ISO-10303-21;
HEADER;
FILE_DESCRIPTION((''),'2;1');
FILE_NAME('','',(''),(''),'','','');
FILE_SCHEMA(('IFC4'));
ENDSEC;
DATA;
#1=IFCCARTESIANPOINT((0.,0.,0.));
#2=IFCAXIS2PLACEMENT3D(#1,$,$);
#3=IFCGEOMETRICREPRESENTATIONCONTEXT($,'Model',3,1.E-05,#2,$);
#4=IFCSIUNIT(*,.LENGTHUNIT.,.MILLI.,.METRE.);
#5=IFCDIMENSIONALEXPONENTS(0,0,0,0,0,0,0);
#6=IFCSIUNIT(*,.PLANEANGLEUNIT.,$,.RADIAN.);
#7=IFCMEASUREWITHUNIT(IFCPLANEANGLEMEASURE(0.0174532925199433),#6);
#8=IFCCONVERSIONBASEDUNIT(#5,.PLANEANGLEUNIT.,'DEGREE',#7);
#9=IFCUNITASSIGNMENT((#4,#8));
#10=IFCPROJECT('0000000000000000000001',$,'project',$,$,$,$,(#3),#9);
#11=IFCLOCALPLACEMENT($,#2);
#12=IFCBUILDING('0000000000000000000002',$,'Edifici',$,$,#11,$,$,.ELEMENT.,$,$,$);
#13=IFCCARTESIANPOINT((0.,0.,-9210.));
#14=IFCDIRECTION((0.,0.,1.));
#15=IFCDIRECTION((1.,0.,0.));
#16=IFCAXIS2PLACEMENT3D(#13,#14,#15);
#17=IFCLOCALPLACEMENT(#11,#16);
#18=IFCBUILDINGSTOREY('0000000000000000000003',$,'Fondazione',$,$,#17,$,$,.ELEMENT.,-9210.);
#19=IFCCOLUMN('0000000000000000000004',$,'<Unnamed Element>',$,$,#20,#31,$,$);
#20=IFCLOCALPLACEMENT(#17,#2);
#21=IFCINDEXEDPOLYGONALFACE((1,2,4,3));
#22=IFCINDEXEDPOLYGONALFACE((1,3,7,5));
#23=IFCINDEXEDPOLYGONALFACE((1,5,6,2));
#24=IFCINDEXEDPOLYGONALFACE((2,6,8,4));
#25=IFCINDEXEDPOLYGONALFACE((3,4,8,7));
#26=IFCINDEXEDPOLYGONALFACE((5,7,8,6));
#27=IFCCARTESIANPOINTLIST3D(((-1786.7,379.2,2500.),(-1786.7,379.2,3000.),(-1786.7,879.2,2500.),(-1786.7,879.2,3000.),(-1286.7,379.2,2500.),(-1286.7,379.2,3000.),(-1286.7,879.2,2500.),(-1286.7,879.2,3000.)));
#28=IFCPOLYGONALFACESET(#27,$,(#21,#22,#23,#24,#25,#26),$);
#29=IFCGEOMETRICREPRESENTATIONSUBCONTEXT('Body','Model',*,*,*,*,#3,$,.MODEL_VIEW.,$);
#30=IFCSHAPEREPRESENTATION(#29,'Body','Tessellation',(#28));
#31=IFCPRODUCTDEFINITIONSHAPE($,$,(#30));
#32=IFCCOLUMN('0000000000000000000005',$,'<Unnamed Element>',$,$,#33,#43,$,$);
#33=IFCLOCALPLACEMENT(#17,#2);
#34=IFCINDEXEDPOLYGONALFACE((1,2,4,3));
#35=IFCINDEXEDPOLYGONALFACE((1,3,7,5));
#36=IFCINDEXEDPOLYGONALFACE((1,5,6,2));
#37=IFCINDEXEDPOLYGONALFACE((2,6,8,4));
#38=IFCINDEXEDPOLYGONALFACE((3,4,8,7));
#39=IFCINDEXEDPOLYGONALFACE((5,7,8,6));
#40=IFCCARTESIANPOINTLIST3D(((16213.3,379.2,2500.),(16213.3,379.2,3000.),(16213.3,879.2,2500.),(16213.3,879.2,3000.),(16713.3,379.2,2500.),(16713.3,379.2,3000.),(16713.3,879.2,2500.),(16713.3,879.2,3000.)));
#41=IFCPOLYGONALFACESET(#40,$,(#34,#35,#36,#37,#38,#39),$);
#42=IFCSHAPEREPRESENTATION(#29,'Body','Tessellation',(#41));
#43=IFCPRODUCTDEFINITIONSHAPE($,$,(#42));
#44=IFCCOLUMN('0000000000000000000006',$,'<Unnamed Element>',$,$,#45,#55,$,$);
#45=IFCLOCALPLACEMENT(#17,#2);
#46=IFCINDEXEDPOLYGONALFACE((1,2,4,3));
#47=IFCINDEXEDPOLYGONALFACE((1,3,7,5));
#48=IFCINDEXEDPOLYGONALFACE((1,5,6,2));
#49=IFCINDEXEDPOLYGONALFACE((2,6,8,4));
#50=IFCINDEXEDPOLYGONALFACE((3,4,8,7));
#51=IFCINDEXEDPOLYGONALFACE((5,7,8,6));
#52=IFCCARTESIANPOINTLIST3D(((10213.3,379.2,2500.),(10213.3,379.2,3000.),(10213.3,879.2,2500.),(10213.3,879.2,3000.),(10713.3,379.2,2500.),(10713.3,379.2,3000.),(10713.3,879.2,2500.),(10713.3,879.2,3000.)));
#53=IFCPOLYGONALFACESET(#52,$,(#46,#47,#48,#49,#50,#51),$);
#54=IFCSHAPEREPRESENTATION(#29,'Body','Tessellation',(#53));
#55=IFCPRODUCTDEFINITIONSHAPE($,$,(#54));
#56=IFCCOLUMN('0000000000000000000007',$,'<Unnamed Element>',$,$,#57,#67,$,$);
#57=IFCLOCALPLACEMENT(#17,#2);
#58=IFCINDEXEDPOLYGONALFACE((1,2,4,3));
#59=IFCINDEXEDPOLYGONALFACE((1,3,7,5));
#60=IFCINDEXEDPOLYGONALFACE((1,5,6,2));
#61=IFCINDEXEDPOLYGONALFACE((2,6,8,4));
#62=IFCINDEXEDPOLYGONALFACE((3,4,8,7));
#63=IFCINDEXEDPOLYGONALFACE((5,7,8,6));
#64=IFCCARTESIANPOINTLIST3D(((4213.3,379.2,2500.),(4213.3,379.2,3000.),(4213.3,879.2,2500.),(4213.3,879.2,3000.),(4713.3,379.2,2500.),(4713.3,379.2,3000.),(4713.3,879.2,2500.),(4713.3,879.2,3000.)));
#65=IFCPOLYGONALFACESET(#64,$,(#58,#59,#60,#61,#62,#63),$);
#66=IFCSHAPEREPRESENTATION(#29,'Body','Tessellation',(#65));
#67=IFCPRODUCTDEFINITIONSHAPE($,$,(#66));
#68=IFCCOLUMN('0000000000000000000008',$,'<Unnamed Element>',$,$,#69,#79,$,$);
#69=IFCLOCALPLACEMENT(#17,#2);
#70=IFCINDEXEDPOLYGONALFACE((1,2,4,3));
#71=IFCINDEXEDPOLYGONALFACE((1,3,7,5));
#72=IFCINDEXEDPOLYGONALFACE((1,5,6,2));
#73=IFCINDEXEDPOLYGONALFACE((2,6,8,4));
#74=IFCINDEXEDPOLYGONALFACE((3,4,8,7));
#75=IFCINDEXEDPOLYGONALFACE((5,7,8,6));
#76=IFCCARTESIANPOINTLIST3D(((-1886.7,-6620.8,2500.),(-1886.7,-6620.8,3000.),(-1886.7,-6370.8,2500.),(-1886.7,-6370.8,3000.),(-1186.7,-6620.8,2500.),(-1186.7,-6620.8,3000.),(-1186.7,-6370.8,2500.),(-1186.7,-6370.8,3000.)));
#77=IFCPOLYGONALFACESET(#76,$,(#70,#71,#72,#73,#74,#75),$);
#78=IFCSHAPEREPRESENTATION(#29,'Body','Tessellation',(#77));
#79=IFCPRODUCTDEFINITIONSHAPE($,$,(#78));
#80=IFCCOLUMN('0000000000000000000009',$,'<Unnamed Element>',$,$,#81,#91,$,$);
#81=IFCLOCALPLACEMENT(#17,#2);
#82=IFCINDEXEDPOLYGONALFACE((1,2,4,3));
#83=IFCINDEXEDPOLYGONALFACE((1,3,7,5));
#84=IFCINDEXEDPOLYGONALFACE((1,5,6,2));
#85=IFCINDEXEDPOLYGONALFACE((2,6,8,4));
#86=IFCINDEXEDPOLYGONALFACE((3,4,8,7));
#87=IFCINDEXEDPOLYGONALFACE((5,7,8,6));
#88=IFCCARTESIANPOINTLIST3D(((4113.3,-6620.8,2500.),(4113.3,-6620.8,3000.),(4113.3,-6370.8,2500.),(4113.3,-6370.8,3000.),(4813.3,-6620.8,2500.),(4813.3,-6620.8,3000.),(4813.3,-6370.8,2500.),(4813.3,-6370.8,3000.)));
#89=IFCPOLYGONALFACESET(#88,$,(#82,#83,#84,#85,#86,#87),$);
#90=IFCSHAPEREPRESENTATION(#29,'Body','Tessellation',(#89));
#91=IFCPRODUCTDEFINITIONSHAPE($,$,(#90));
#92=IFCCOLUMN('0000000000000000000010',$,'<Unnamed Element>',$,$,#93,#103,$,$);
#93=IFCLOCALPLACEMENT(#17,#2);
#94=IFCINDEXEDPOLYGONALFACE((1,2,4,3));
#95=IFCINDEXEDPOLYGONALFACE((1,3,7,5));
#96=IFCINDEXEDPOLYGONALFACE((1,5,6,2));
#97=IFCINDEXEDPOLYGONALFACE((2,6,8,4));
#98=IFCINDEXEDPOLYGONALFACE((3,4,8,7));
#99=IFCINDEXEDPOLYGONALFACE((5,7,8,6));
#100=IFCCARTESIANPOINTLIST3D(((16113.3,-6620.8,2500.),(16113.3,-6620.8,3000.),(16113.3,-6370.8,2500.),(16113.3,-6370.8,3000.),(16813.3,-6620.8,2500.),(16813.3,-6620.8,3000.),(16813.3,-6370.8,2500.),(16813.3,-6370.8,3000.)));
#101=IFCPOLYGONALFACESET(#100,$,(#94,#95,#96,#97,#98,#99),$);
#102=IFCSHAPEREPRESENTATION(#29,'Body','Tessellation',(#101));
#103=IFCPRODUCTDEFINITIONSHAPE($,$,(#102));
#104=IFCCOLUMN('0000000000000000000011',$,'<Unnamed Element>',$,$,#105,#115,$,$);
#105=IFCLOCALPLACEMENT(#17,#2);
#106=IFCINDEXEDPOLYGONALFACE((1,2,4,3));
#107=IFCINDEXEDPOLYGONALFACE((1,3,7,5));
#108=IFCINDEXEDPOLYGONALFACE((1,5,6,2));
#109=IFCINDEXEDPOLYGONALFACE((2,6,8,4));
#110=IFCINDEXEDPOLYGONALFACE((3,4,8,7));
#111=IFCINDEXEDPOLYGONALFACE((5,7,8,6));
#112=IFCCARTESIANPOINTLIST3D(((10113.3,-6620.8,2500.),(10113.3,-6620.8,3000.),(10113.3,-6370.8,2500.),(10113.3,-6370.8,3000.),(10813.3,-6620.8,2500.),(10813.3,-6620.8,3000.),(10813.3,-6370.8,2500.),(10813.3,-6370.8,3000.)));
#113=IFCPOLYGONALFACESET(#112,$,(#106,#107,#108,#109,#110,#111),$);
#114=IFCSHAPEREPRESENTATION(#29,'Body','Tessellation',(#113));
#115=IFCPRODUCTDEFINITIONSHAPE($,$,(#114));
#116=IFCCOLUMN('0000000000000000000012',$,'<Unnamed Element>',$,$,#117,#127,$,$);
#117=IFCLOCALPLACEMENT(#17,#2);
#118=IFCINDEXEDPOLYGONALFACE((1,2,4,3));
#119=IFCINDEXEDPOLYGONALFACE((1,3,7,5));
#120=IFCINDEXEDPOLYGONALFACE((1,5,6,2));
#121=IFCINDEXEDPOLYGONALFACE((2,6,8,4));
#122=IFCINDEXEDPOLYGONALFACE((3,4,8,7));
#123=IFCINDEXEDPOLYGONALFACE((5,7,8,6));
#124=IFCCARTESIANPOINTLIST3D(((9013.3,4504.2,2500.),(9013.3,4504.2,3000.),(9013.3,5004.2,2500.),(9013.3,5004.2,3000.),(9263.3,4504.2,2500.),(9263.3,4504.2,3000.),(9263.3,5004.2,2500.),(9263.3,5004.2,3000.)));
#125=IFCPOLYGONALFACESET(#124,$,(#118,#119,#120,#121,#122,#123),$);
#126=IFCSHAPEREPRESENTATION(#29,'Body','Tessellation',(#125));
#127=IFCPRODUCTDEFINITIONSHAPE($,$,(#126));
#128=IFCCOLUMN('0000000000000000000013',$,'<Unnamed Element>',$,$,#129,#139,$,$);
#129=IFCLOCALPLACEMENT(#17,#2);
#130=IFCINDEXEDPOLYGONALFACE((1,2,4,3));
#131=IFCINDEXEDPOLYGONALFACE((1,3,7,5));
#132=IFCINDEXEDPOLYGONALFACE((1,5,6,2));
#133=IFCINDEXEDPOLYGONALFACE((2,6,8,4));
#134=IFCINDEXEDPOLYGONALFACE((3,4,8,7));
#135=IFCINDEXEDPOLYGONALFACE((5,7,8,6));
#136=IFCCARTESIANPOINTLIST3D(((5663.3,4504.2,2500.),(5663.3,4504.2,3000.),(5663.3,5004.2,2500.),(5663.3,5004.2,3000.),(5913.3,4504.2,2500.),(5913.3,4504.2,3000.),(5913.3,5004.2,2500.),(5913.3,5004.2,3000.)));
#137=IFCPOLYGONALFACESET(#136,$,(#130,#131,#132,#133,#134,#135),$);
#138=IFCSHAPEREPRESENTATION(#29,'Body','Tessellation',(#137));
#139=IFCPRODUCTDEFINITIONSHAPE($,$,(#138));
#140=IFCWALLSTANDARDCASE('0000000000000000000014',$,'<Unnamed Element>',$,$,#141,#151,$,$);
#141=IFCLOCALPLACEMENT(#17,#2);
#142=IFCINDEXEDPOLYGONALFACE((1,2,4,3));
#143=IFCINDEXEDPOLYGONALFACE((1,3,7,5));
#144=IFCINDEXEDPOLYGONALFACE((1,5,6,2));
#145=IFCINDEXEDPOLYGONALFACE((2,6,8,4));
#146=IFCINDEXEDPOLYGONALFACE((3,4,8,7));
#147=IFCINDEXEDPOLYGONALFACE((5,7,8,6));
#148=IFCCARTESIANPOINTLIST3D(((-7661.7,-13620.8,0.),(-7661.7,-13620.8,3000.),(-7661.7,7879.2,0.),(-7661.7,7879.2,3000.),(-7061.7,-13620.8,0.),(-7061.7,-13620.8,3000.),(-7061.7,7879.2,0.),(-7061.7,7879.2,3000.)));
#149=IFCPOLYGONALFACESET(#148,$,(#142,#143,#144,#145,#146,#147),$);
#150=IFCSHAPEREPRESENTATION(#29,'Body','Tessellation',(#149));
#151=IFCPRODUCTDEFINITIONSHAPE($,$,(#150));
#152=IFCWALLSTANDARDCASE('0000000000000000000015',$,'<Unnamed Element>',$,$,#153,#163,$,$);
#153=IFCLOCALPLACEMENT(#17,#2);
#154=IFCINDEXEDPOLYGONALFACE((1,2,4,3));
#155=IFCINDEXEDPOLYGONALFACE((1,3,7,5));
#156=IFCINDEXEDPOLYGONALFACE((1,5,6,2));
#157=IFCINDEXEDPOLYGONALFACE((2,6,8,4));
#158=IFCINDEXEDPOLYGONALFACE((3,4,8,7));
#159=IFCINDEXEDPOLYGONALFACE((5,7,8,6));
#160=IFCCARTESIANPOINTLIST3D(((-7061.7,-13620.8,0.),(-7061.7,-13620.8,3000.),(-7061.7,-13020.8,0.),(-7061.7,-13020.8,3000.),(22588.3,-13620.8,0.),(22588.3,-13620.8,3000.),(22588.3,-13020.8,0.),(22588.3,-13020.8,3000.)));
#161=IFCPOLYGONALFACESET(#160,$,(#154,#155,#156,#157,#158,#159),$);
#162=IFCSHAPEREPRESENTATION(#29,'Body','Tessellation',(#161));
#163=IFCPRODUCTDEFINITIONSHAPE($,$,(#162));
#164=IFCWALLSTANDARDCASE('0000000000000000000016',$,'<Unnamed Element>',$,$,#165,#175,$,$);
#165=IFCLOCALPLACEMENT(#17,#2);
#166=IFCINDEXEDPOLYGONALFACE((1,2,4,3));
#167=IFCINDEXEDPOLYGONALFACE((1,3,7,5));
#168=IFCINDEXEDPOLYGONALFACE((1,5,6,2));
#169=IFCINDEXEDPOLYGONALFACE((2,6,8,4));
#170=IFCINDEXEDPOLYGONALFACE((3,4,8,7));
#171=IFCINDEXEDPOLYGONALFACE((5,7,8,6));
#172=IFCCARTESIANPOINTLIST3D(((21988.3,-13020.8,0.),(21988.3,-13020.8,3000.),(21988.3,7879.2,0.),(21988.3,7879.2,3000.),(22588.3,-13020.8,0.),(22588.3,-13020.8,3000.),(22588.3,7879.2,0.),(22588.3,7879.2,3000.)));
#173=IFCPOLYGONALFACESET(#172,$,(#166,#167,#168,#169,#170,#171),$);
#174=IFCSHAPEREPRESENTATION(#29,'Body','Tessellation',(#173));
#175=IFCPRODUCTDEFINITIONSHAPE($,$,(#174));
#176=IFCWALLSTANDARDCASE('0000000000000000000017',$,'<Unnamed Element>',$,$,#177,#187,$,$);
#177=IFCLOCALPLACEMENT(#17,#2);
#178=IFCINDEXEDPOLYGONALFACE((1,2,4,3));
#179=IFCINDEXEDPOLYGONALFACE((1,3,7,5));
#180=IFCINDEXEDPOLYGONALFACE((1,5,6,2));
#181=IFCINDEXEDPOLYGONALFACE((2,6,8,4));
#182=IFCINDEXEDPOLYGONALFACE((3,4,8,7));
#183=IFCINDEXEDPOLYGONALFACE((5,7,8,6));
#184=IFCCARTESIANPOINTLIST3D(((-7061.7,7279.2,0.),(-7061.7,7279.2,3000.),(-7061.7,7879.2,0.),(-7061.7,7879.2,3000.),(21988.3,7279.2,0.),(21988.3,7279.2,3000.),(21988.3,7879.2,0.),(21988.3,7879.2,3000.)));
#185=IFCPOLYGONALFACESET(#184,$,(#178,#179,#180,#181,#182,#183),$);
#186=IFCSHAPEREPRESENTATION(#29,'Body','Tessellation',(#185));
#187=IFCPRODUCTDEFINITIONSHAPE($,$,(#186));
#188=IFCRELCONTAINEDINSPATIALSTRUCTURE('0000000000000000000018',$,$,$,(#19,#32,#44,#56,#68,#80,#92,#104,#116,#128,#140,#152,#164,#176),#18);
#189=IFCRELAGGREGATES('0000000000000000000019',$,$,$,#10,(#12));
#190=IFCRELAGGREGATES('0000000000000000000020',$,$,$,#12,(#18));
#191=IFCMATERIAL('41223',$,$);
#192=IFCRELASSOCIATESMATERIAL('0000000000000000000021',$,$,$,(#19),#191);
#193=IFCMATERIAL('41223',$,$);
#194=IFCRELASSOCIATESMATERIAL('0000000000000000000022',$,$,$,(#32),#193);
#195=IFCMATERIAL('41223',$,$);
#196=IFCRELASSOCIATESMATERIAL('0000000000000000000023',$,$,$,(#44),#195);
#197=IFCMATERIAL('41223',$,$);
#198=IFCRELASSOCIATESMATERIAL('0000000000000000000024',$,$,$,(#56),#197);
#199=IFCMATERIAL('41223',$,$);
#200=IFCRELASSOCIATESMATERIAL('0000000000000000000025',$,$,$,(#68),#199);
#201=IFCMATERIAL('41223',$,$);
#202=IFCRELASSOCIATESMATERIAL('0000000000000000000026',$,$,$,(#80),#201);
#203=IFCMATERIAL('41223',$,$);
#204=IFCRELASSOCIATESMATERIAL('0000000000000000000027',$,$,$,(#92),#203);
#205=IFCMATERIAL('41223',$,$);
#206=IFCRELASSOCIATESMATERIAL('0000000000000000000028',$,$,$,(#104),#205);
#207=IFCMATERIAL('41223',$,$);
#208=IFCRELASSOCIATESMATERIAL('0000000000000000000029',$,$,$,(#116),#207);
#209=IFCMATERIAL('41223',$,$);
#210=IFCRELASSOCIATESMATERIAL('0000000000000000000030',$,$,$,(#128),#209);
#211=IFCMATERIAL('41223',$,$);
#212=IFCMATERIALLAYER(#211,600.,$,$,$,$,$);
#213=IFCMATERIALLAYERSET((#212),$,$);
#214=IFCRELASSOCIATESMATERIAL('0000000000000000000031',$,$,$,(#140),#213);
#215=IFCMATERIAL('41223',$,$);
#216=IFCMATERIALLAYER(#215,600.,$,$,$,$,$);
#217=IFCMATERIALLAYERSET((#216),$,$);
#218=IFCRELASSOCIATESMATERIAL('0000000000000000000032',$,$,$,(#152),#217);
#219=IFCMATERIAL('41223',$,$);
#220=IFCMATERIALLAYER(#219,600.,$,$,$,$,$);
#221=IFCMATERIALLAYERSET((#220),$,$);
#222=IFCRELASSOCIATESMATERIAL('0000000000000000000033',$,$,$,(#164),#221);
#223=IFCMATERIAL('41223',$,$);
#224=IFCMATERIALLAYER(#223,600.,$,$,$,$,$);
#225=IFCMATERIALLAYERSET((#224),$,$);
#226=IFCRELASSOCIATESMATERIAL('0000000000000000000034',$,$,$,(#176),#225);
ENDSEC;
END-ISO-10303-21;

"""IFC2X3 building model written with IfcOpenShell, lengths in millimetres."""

from ifc_helpers import new_model, entity, si_unit, converted_unit, frame, frame_2d, origin, origin_with_axes, place, context, subcontext, project, spatial, rectangle, extrude, material, layer, layer_set, layer_usage, element, save


model = new_model("IFC2X3")

# Units and contexts
model_context = context("Model", 3, precision=1e-05, world=origin())
body_context = subcontext(model_context, "Body", "Model", "MODEL_VIEW")
ifc_project = project(units=[si_unit("LENGTHUNIT", "METRE", prefix="MILLI"), converted_unit("PLANEANGLEUNIT", "DEGREE", entity("IfcPlaneAngleMeasure", 0.0174532925199433), si_unit("PLANEANGLEUNIT", "RADIAN"), dimensions=[0, 0, 0, 0, 0, 0, 0])], contexts=[model_context])

# Building, storey
building_placement = place(None, origin())
building = spatial("IfcBuilding", under=ifc_project, at=building_placement, Name="Edifici", CompositionType="ELEMENT")
storey_placement = place(building_placement, frame((0.0, 0.0, -9210.0), z_axis=(0.0, 0.0, 1.0), x_axis=(1.0, 0.0, 0.0)))
storey = spatial("IfcBuildingStorey", under=building, at=storey_placement, Name="Fondazione", CompositionType="ELEMENT", Elevation=-9210.0)

# Columns
ifc_material_1 = material(Name="41223")
column_1_placement = place(storey_placement, frame((-1786.7, 379.2, 2500.0), z_axis=(0.0, 0.0, 1.0), x_axis=(1.0, 0.0, 0.0)))
element("IfcColumn", 1, at=column_1_placement, inside=storey, material=ifc_material_1, Name="<Unnamed Element>", context=body_context, shape_type="SweptSolid", body=[
    extrude(rectangle(XDim=500.0, YDim=500.0, at=frame_2d((250.0, 250.0), x_axis=(1.0, 0.0))), origin_with_axes(), (0.0, 0.0, 1.0), 500.0),
])
ifc_material_2 = material(Name="41223")
column_2_placement = place(storey_placement, frame((16213.3, 379.2, 2500.0), z_axis=(0.0, 0.0, 1.0), x_axis=(1.0, 0.0, 0.0)))
element("IfcColumn", 2, at=column_2_placement, inside=storey, material=ifc_material_2, Name="<Unnamed Element>", context=body_context, shape_type="SweptSolid", body=[
    extrude(rectangle(XDim=500.0, YDim=500.0, at=frame_2d((250.0, 250.0), x_axis=(1.0, 0.0))), origin_with_axes(), (0.0, 0.0, 1.0), 500.0),
])
ifc_material_3 = material(Name="41223")
column_3_placement = place(storey_placement, frame((10213.3, 379.2, 2500.0), z_axis=(0.0, 0.0, 1.0), x_axis=(1.0, 0.0, 0.0)))
element("IfcColumn", 3, at=column_3_placement, inside=storey, material=ifc_material_3, Name="<Unnamed Element>", context=body_context, shape_type="SweptSolid", body=[
    extrude(rectangle(XDim=500.0, YDim=500.0, at=frame_2d((250.0, 250.0), x_axis=(1.0, 0.0))), origin_with_axes(), (0.0, 0.0, 1.0), 500.0),
])
ifc_material_4 = material(Name="41223")
column_4_placement = place(storey_placement, frame((4213.3, 379.2, 2500.0), z_axis=(0.0, 0.0, 1.0), x_axis=(1.0, 0.0, 0.0)))
element("IfcColumn", 4, at=column_4_placement, inside=storey, material=ifc_material_4, Name="<Unnamed Element>", context=body_context, shape_type="SweptSolid", body=[
    extrude(rectangle(XDim=500.0, YDim=500.0, at=frame_2d((250.0, 250.0), x_axis=(1.0, 0.0))), origin_with_axes(), (0.0, 0.0, 1.0), 500.0),
])
ifc_material_5 = material(Name="41223")
column_5_placement = place(storey_placement, frame((-1186.7, -6620.8, 2500.0), z_axis=(0.0, 0.0, 1.0), x_axis=(1.0, 0.0, 0.0)))
element("IfcColumn", 5, at=column_5_placement, inside=storey, material=ifc_material_5, Name="<Unnamed Element>", context=body_context, shape_type="SweptSolid", body=[
    extrude(rectangle(XDim=250.0, YDim=700.0, at=frame_2d((-350.0, 125.0), x_axis=(0.0, 1.0))), origin_with_axes(), (0.0, 0.0, 1.0), 500.0),
])
ifc_material_6 = material(Name="41223")
column_6_placement = place(storey_placement, frame((4813.3, -6620.8, 2500.0), z_axis=(0.0, 0.0, 1.0), x_axis=(1.0, 0.0, 0.0)))
element("IfcColumn", 6, at=column_6_placement, inside=storey, material=ifc_material_6, Name="<Unnamed Element>", context=body_context, shape_type="SweptSolid", body=[
    extrude(rectangle(XDim=250.0, YDim=700.0, at=frame_2d((-350.0, 125.0), x_axis=(0.0, 1.0))), origin_with_axes(), (0.0, 0.0, 1.0), 500.0),
])
ifc_material_7 = material(Name="41223")
column_7_placement = place(storey_placement, frame((16813.3, -6620.8, 2500.0), z_axis=(0.0, 0.0, 1.0), x_axis=(1.0, 0.0, 0.0)))
element("IfcColumn", 7, at=column_7_placement, inside=storey, material=ifc_material_7, Name="<Unnamed Element>", context=body_context, shape_type="SweptSolid", body=[
    extrude(rectangle(XDim=250.0, YDim=700.0, at=frame_2d((-350.0, 125.0), x_axis=(0.0, 1.0))), origin_with_axes(), (0.0, 0.0, 1.0), 500.0),
])
ifc_material_8 = material(Name="41223")
column_8_placement = place(storey_placement, frame((10813.3, -6620.8, 2500.0), z_axis=(0.0, 0.0, 1.0), x_axis=(1.0, 0.0, 0.0)))
element("IfcColumn", 8, at=column_8_placement, inside=storey, material=ifc_material_8, Name="<Unnamed Element>", context=body_context, shape_type="SweptSolid", body=[
    extrude(rectangle(XDim=250.0, YDim=700.0, at=frame_2d((-350.0, 125.0), x_axis=(0.0, 1.0))), origin_with_axes(), (0.0, 0.0, 1.0), 500.0),
])
ifc_material_9 = material(Name="41223")
column_9_placement = place(storey_placement, frame((9263.3, 5004.2, 2500.0), z_axis=(0.0, 0.0, 1.0), x_axis=(1.0, 0.0, 0.0)))
element("IfcColumn", 9, at=column_9_placement, inside=storey, material=ifc_material_9, Name="<Unnamed Element>", context=body_context, shape_type="SweptSolid", body=[
    extrude(rectangle(XDim=250.0, YDim=500.0, at=frame_2d((-125.0, -250.0), x_axis=(-1.0, 0.0))), origin_with_axes(), (0.0, 0.0, 1.0), 500.0),
])
ifc_material_10 = material(Name="41223")
column_10_placement = place(storey_placement, frame((5913.3, 5004.2, 2500.0), z_axis=(0.0, 0.0, 1.0), x_axis=(1.0, 0.0, 0.0)))
element("IfcColumn", 10, at=column_10_placement, inside=storey, material=ifc_material_10, Name="<Unnamed Element>", context=body_context, shape_type="SweptSolid", body=[
    extrude(rectangle(XDim=250.0, YDim=500.0, at=frame_2d((-125.0, -250.0), x_axis=(-1.0, 0.0))), origin_with_axes(), (0.0, 0.0, 1.0), 500.0),
])

# Walls
ifc_material_11 = material(Name="41223")
ifc_layer_1 = layer(ifc_material_11, 600.0)
ifc_layer_set_1 = layer_set([ifc_layer_1])
ifc_layer_usage_1 = layer_usage(ifc_layer_set_1, "AXIS2", "POSITIVE", 0.0)
wall_1_placement = place(storey_placement, frame((-7661.7, 7879.2, 0.0), z_axis=(0.0, 0.0, 1.0), x_axis=(0.0, -1.0, 0.0)))
element("IfcWallStandardCase", 11, at=wall_1_placement, inside=storey, material=ifc_layer_usage_1, Name="<Unnamed Element>", context=body_context, shape_type="SweptSolid", body=[
    extrude(rectangle(XDim=21500.0, YDim=600.0, at=frame_2d((10750.0, 300.0), x_axis=(1.0, 0.0))), origin_with_axes(), (0.0, 0.0, 1.0), 3000.0),
])
ifc_material_12 = material(Name="41223")
ifc_layer_2 = layer(ifc_material_12, 600.0)
ifc_layer_set_2 = layer_set([ifc_layer_2])
ifc_layer_usage_2 = layer_usage(ifc_layer_set_2, "AXIS2", "POSITIVE", 0.0)
wall_2_placement = place(storey_placement, frame((-7061.7, -13620.8, 0.0), z_axis=(0.0, 0.0, 1.0), x_axis=(1.0, 0.0, 0.0)))
element("IfcWallStandardCase", 12, at=wall_2_placement, inside=storey, material=ifc_layer_usage_2, Name="<Unnamed Element>", context=body_context, shape_type="SweptSolid", body=[
    extrude(rectangle(XDim=29650.0, YDim=600.0, at=frame_2d((14825.0, 300.0), x_axis=(1.0, 0.0))), origin_with_axes(), (0.0, 0.0, 1.0), 3000.0),
])
ifc_material_13 = material(Name="41223")
ifc_layer_3 = layer(ifc_material_13, 600.0)
ifc_layer_set_3 = layer_set([ifc_layer_3])
ifc_layer_usage_3 = layer_usage(ifc_layer_set_3, "AXIS2", "POSITIVE", 0.0)
wall_3_placement = place(storey_placement, frame((22588.3, -13020.8, 0.0), z_axis=(0.0, 0.0, 1.0), x_axis=(0.0, 1.0, 0.0)))
element("IfcWallStandardCase", 13, at=wall_3_placement, inside=storey, material=ifc_layer_usage_3, Name="<Unnamed Element>", context=body_context, shape_type="SweptSolid", body=[
    extrude(rectangle(XDim=20900.0, YDim=600.0, at=frame_2d((10450.0, 300.0), x_axis=(1.0, 0.0))), origin_with_axes(), (0.0, 0.0, 1.0), 3000.0),
])
ifc_material_14 = material(Name="41223")
ifc_layer_4 = layer(ifc_material_14, 600.0)
ifc_layer_set_4 = layer_set([ifc_layer_4])
ifc_layer_usage_4 = layer_usage(ifc_layer_set_4, "AXIS2", "POSITIVE", 0.0)
wall_4_placement = place(storey_placement, frame((21988.3, 7879.2, 0.0), z_axis=(0.0, 0.0, 1.0), x_axis=(-1.0, 0.0, 0.0)))
element("IfcWallStandardCase", 14, at=wall_4_placement, inside=storey, material=ifc_layer_usage_4, Name="<Unnamed Element>", context=body_context, shape_type="SweptSolid", body=[
    extrude(rectangle(XDim=29050.0, YDim=600.0, at=frame_2d((14525.0, 300.0), x_axis=(1.0, 0.0))), origin_with_axes(), (0.0, 0.0, 1.0), 3000.0),
])

save(model, "model.ifc")
